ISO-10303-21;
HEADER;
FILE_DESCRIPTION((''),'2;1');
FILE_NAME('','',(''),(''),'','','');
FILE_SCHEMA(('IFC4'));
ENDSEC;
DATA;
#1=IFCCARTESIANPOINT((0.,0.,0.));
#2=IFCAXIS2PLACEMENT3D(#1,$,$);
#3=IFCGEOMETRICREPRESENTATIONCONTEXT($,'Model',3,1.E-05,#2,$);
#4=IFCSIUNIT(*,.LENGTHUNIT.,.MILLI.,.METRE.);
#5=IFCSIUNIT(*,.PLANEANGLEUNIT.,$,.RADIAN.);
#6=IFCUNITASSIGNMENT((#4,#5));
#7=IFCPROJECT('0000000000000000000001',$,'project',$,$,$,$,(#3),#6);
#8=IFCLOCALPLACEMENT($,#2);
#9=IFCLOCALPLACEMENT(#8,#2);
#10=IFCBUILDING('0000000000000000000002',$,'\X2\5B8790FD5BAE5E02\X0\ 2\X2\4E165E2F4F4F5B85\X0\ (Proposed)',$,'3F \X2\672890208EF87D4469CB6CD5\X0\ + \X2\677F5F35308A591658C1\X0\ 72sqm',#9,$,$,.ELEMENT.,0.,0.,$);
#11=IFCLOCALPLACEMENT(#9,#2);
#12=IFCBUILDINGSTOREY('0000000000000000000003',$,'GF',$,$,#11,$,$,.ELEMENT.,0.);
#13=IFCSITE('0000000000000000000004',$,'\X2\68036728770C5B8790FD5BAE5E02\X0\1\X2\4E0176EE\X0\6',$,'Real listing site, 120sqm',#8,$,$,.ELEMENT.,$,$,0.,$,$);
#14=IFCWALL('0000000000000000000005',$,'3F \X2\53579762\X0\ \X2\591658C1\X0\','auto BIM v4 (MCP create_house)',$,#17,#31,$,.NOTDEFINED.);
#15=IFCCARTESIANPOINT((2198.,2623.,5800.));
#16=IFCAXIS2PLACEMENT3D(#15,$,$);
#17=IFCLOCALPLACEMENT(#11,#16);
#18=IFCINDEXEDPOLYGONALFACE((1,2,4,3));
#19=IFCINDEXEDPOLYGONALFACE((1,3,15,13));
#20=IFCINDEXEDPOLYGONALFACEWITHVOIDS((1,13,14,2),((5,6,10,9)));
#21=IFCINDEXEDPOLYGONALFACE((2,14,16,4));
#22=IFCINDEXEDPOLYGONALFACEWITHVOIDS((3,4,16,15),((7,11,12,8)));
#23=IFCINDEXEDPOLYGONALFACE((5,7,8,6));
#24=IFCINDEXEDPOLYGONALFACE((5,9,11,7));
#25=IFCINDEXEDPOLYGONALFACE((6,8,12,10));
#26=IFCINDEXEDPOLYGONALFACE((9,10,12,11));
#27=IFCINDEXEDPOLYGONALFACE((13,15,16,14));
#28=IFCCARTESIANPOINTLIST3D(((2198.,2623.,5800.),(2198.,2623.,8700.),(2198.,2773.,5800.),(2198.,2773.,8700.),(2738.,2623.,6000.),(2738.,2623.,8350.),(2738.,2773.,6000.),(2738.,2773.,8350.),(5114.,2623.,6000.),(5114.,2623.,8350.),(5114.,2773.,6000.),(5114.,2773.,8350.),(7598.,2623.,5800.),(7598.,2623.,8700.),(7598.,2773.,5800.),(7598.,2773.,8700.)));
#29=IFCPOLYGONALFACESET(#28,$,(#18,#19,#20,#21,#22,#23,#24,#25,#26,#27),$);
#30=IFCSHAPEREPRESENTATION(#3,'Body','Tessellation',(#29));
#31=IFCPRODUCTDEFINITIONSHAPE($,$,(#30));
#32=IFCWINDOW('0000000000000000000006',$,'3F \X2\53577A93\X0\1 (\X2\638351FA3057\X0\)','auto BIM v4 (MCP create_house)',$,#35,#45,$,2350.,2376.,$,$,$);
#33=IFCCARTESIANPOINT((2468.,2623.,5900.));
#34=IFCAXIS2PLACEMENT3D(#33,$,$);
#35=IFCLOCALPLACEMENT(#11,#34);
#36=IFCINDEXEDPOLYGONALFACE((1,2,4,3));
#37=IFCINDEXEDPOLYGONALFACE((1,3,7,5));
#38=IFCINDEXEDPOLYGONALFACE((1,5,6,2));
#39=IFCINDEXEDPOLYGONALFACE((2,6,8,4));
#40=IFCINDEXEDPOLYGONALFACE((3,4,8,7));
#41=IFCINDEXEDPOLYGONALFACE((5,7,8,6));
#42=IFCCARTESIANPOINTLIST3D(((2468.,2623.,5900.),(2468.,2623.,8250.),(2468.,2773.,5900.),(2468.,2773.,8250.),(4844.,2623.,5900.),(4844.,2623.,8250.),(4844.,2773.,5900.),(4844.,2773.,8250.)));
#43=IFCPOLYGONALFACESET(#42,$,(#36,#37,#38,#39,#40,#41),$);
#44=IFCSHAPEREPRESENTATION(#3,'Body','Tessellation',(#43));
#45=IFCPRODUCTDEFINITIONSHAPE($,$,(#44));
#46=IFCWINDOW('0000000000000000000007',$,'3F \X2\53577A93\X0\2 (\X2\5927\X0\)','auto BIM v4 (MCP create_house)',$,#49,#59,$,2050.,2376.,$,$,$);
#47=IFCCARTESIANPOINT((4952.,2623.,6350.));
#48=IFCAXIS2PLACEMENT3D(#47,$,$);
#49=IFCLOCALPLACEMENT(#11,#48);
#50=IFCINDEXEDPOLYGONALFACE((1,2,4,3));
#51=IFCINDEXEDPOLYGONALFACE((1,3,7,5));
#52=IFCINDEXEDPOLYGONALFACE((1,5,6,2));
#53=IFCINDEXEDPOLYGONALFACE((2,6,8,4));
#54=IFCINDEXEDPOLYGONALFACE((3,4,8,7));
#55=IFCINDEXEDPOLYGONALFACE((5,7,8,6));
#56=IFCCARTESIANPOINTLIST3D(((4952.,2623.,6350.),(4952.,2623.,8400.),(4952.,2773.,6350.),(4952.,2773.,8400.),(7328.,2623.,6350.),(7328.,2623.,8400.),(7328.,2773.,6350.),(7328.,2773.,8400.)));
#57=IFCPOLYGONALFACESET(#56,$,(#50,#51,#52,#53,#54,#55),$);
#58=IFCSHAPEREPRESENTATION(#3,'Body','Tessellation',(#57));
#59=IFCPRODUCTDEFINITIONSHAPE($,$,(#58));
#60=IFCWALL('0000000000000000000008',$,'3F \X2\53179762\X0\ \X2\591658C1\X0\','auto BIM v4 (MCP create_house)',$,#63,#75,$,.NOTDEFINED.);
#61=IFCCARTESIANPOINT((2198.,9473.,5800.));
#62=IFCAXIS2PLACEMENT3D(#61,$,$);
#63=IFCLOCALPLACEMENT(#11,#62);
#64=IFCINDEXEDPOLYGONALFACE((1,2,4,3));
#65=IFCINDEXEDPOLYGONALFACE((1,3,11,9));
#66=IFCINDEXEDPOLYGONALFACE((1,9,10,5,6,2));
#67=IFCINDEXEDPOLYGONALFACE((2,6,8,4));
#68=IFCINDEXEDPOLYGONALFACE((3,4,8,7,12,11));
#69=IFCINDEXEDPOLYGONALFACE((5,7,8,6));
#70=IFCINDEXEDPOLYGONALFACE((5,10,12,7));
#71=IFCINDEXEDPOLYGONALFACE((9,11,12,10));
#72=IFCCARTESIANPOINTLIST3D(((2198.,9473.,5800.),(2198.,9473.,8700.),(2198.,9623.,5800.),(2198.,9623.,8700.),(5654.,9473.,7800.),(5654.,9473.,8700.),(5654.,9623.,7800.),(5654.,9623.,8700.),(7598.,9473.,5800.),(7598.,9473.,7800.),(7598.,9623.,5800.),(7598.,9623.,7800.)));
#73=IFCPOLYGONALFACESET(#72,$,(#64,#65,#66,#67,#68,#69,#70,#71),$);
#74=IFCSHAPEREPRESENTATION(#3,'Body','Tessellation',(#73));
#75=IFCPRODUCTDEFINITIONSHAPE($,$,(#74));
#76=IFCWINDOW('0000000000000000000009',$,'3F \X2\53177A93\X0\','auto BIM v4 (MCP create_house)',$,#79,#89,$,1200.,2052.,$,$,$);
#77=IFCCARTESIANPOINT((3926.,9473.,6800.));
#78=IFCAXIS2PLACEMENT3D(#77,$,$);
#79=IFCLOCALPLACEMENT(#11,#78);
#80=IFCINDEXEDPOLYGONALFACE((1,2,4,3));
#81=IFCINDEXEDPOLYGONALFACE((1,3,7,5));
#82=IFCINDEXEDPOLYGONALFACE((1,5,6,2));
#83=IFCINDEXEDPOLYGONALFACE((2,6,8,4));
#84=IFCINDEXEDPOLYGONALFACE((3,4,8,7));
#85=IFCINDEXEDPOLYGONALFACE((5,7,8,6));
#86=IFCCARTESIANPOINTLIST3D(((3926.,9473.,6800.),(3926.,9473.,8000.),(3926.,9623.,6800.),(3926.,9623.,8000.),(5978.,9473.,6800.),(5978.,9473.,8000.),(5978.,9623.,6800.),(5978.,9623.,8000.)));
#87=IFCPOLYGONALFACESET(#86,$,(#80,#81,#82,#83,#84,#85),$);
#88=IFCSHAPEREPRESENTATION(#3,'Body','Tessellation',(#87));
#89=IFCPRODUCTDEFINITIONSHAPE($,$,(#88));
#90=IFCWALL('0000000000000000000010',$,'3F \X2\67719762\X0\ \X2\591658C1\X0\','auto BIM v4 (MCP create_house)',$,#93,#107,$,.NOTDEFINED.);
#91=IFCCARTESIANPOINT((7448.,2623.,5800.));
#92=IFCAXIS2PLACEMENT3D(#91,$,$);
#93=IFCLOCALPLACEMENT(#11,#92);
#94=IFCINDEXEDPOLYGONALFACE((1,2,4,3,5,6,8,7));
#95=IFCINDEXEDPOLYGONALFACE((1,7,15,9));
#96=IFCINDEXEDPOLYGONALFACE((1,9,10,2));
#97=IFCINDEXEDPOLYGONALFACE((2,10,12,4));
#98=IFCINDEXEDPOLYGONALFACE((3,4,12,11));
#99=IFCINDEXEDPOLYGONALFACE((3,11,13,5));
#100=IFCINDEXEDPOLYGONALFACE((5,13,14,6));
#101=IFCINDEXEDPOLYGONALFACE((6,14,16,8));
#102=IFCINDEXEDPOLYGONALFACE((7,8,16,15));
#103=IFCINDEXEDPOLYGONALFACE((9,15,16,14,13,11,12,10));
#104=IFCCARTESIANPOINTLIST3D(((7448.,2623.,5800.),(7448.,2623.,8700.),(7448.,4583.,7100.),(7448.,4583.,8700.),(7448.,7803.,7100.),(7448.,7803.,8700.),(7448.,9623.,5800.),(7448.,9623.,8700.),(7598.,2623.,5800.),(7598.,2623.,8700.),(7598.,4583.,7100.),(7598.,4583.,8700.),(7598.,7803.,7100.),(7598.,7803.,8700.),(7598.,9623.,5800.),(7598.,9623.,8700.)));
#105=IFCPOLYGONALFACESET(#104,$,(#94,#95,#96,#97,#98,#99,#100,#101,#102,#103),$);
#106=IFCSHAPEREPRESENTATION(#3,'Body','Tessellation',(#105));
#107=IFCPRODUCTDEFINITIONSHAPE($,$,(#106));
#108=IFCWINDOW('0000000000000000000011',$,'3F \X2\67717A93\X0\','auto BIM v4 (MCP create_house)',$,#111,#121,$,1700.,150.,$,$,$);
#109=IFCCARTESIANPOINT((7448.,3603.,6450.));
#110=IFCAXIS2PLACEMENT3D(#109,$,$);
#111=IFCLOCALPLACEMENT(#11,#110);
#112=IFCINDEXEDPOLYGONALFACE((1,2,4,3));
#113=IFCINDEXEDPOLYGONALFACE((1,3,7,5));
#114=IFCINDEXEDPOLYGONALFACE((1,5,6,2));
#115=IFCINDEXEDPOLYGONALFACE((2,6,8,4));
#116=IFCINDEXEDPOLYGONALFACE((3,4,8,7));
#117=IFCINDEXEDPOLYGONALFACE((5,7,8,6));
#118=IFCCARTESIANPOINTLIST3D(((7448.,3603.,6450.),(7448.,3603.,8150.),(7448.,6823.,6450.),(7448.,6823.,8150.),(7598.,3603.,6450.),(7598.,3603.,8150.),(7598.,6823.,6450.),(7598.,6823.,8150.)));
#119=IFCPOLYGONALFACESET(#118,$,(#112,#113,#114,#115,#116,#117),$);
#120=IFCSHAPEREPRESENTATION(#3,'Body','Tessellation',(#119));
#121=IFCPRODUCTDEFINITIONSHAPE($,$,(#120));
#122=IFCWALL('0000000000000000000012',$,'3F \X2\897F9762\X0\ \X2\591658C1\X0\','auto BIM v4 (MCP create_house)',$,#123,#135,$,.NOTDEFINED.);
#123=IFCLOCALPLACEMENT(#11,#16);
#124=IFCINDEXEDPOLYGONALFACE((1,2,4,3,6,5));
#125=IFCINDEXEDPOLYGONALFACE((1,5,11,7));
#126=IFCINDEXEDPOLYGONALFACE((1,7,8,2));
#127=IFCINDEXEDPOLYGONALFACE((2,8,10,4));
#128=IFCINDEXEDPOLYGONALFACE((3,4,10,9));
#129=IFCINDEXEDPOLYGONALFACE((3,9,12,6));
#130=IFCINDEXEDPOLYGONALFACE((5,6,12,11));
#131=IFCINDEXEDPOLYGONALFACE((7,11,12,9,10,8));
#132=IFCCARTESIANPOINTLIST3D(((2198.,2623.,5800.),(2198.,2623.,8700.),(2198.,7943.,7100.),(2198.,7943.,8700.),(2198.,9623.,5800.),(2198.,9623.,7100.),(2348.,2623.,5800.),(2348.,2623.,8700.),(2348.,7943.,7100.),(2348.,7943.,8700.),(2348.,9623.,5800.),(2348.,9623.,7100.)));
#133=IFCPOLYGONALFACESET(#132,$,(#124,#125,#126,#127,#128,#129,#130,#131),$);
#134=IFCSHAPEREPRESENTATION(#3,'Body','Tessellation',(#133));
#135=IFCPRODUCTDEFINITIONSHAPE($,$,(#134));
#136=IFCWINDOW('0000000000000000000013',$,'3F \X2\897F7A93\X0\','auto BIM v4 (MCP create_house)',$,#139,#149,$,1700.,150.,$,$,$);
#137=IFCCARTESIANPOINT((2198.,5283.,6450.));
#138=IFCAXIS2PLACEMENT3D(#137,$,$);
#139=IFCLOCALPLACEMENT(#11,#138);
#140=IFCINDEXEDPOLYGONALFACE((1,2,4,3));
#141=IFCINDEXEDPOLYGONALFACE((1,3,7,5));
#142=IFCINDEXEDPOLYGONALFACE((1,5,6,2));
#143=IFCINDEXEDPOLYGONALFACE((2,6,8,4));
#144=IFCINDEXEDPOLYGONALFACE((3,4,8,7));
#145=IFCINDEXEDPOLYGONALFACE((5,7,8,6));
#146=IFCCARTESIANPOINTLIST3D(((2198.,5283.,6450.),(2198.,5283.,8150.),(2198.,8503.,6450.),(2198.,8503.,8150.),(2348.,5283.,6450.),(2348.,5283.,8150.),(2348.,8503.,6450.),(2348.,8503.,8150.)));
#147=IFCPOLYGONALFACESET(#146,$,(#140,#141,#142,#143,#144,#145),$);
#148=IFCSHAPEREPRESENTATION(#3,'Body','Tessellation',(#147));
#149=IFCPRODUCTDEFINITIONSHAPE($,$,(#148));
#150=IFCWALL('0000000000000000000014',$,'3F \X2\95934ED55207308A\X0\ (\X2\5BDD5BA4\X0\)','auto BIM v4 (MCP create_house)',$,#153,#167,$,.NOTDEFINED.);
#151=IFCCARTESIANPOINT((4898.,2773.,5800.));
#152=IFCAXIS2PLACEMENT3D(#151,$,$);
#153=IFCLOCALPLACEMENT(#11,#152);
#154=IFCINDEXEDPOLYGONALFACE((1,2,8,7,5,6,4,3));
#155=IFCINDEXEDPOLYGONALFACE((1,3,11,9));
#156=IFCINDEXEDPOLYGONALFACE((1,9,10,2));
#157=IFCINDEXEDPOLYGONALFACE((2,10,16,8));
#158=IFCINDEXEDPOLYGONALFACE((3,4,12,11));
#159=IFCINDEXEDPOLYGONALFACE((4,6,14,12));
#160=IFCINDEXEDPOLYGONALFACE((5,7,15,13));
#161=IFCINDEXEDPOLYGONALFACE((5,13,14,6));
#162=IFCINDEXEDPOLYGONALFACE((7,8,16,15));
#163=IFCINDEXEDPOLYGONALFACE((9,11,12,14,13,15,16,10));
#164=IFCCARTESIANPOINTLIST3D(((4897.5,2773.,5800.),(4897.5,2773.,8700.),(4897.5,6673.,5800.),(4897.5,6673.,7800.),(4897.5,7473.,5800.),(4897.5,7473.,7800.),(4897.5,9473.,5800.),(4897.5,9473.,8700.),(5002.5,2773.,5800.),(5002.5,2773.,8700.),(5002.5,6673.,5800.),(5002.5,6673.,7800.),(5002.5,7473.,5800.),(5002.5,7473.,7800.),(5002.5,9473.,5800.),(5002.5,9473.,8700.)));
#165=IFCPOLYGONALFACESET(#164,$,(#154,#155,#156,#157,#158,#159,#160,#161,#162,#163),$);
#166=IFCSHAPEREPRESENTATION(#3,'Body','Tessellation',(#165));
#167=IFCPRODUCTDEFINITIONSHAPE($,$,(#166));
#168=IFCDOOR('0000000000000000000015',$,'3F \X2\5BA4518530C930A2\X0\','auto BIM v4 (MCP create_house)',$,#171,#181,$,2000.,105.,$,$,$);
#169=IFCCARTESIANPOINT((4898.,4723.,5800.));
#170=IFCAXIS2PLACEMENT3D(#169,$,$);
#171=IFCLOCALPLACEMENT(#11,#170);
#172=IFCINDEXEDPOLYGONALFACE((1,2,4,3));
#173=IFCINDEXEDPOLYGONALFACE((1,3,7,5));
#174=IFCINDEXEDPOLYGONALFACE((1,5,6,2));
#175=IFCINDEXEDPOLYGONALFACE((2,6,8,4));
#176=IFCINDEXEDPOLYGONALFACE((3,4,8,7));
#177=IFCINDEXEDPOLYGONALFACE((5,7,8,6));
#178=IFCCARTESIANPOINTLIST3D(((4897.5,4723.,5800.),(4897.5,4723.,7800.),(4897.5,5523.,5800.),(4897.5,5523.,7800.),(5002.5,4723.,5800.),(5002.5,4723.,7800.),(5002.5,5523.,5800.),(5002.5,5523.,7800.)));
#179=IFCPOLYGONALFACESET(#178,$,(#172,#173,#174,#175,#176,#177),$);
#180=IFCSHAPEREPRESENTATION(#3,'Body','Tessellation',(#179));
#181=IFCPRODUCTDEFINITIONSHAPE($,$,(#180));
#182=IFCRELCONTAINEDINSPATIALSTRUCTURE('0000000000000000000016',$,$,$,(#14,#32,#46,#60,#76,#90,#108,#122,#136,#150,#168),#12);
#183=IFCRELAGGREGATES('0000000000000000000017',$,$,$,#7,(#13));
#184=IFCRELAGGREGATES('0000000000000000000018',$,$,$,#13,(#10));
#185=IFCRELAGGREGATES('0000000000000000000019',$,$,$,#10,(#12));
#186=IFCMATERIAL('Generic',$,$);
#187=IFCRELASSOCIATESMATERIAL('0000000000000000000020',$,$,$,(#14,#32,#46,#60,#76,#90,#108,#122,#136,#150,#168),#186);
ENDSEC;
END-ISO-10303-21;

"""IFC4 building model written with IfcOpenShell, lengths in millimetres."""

from ifc_helpers import new_model, si_unit, frame, frame_2d, origin, place, context, project, spatial, rectangle, extrude, material, element, fill, save


model = new_model("IFC4")

# Units and contexts
model_context = context("Model", 3, precision=1e-05, world=origin())
ifc_project = project(units=[si_unit("LENGTHUNIT", "METRE", prefix="MILLI"), si_unit("PLANEANGLEUNIT", "RADIAN")], contexts=[model_context])

# Site, building, storey
site_placement = place(None, origin())
site = spatial("IfcSite", under=ifc_project, at=site_placement, Name="栃木県宇都宮市1丁目6", ObjectType="Real listing site, 120sqm", CompositionType="ELEMENT", RefElevation=0.0)
building_placement = place(site_placement, origin())
building = spatial("IfcBuilding", under=site, at=building_placement, Name="宇都宮市 2世帯住宅 (Proposed)", ObjectType="3F 木造軸組構法 + 板張り外壁 72sqm", CompositionType="ELEMENT", ElevationOfRefHeight=0.0, ElevationOfTerrain=0.0)
storey_placement = place(building_placement, origin())
storey = spatial("IfcBuildingStorey", under=building, at=storey_placement, Name="GF", CompositionType="ELEMENT", Elevation=0.0)

# Shared definitions
ifc_material = material(Name="Generic")

# Wall, openings, windows
wall_1_placement = place(storey_placement, frame((2198.0, 2623.0, 5800.0)))
wall_1 = element("IfcWall", 1, at=wall_1_placement, inside=storey, material=ifc_material, Name="3F 南面 外壁", Description="auto BIM v4 (MCP create_house)", PredefinedType="NOTDEFINED", context=model_context, shape_type="SweptSolid", body=[
    extrude(rectangle(XDim=5400.0, YDim=150.0, at=frame_2d((2700.0, 75.0))), frame((2198.0, 2623.0, 5800.0)), (0.0, 0.0, 1.0), 2900.0),
])
opening_1_placement = place(storey_placement, frame((2468.0, 2623.0, 5900.0)))
opening_1 = element("IfcOpeningElement", 2, at=opening_1_placement, cuts=wall_1, PredefinedType="NOTDEFINED", context=model_context, shape_type="SweptSolid", body=[
    extrude(rectangle(XDim=2376.0, YDim=150.0, at=frame_2d((1188.0, 75.0))), frame((2468.0, 2623.0, 5900.0)), (0.0, 0.0, 1.0), 2350.0),
])
opening_2_placement = place(storey_placement, frame((4952.0, 2623.0, 6350.0)))
opening_2 = element("IfcOpeningElement", 3, at=opening_2_placement, cuts=wall_1, PredefinedType="NOTDEFINED", context=model_context, shape_type="SweptSolid", body=[
    extrude(rectangle(XDim=2376.0, YDim=150.0, at=frame_2d((1188.0, 75.0))), frame((4952.0, 2623.0, 6350.0)), (0.0, 0.0, 1.0), 2050.0),
])
window_1_placement = place(storey_placement, frame((2468.0, 2623.0, 5900.0)))
window_1 = element("IfcWindow", 4, at=window_1_placement, inside=storey, material=ifc_material, Name="3F 南窓1 (掃出し)", Description="auto BIM v4 (MCP create_house)", OverallHeight=2350.0, OverallWidth=2376.0, context=model_context, shape_type="SweptSolid", body=[
    extrude(rectangle(XDim=2376.0, YDim=150.0, at=frame_2d((1188.0, 75.0))), frame((2468.0, 2623.0, 5900.0)), (0.0, 0.0, 1.0), 2350.0),
])
fill(opening_1, window_1)
window_2_placement = place(storey_placement, frame((4952.0, 2623.0, 6350.0)))
window_2 = element("IfcWindow", 5, at=window_2_placement, inside=storey, material=ifc_material, Name="3F 南窓2 (大)", Description="auto BIM v4 (MCP create_house)", OverallHeight=2050.0, OverallWidth=2376.0, context=model_context, shape_type="SweptSolid", body=[
    extrude(rectangle(XDim=2376.0, YDim=150.0, at=frame_2d((1188.0, 75.0))), frame((4952.0, 2623.0, 6350.0)), (0.0, 0.0, 1.0), 2050.0),
])
fill(opening_2, window_2)

# Walls, openings, windows
wall_2_placement = place(storey_placement, frame((2198.0, 9473.0, 5800.0)))
wall_2 = element("IfcWall", 6, at=wall_2_placement, inside=storey, material=ifc_material, Name="3F 北面 外壁", Description="auto BIM v4 (MCP create_house)", PredefinedType="NOTDEFINED", context=model_context, shape_type="SweptSolid", body=[
    extrude(rectangle(XDim=5400.0, YDim=150.0, at=frame_2d((2700.0, 75.0))), frame((2198.0, 9473.0, 5800.0)), (0.0, 0.0, 1.0), 2900.0),
])
opening_3_placement = place(storey_placement, frame((3926.0, 9473.0, 6800.0)))
opening_3 = element("IfcOpeningElement", 7, at=opening_3_placement, cuts=wall_2, PredefinedType="NOTDEFINED", context=model_context, shape_type="SweptSolid", body=[
    extrude(rectangle(XDim=2052.0, YDim=150.0, at=frame_2d((1026.0, 75.0))), frame((3926.0, 9473.0, 6800.0)), (0.0, 0.0, 1.0), 1200.0),
])
window_3_placement = place(storey_placement, frame((3926.0, 9473.0, 6800.0)))
window_3 = element("IfcWindow", 8, at=window_3_placement, inside=storey, material=ifc_material, Name="3F 北窓", Description="auto BIM v4 (MCP create_house)", OverallHeight=1200.0, OverallWidth=2052.0, context=model_context, shape_type="SweptSolid", body=[
    extrude(rectangle(XDim=2052.0, YDim=150.0, at=frame_2d((1026.0, 75.0))), frame((3926.0, 9473.0, 6800.0)), (0.0, 0.0, 1.0), 1200.0),
])
fill(opening_3, window_3)
wall_3_placement = place(storey_placement, frame((7448.0, 2623.0, 5800.0)))
wall_3 = element("IfcWall", 9, at=wall_3_placement, inside=storey, material=ifc_material, Name="3F 東面 外壁", Description="auto BIM v4 (MCP create_house)", PredefinedType="NOTDEFINED", context=model_context, shape_type="SweptSolid", body=[
    extrude(rectangle(XDim=150.0, YDim=7000.0, at=frame_2d((75.0, 3500.0))), frame((7448.0, 2623.0, 5800.0)), (0.0, 0.0, 1.0), 2900.0),
])
opening_4_placement = place(storey_placement, frame((7448.0, 3603.0, 6450.0)))
opening_4 = element("IfcOpeningElement", 10, at=opening_4_placement, cuts=wall_3, PredefinedType="NOTDEFINED", context=model_context, shape_type="SweptSolid", body=[
    extrude(rectangle(XDim=150.0, YDim=3220.0, at=frame_2d((75.0, 1610.0))), frame((7448.0, 3603.0, 6450.0)), (0.0, 0.0, 1.0), 1700.0),
])
window_4_placement = place(storey_placement, frame((7448.0, 3603.0, 6450.0)))
window_4 = element("IfcWindow", 11, at=window_4_placement, inside=storey, material=ifc_material, Name="3F 東窓", Description="auto BIM v4 (MCP create_house)", OverallHeight=1700.0, OverallWidth=150.0, context=model_context, shape_type="SweptSolid", body=[
    extrude(rectangle(XDim=150.0, YDim=3220.0, at=frame_2d((75.0, 1610.0))), frame((7448.0, 3603.0, 6450.0)), (0.0, 0.0, 1.0), 1700.0),
])
fill(opening_4, window_4)
wall_4_placement = place(storey_placement, frame((2198.0, 2623.0, 5800.0)))
wall_4 = element("IfcWall", 12, at=wall_4_placement, inside=storey, material=ifc_material, Name="3F 西面 外壁", Description="auto BIM v4 (MCP create_house)", PredefinedType="NOTDEFINED", context=model_context, shape_type="SweptSolid", body=[
    extrude(rectangle(XDim=150.0, YDim=7000.0, at=frame_2d((75.0, 3500.0))), frame((2198.0, 2623.0, 5800.0)), (0.0, 0.0, 1.0), 2900.0),
])
opening_5_placement = place(storey_placement, frame((2198.0, 5283.0, 6450.0)))
opening_5 = element("IfcOpeningElement", 13, at=opening_5_placement, cuts=wall_4, PredefinedType="NOTDEFINED", context=model_context, shape_type="SweptSolid", body=[
    extrude(rectangle(XDim=150.0, YDim=3220.0, at=frame_2d((75.0, 1610.0))), frame((2198.0, 5283.0, 6450.0)), (0.0, 0.0, 1.0), 1700.0),
])
window_5_placement = place(storey_placement, frame((2198.0, 5283.0, 6450.0)))
window_5 = element("IfcWindow", 14, at=window_5_placement, inside=storey, material=ifc_material, Name="3F 西窓", Description="auto BIM v4 (MCP create_house)", OverallHeight=1700.0, OverallWidth=150.0, context=model_context, shape_type="SweptSolid", body=[
    extrude(rectangle(XDim=150.0, YDim=3220.0, at=frame_2d((75.0, 1610.0))), frame((2198.0, 5283.0, 6450.0)), (0.0, 0.0, 1.0), 1700.0),
])
fill(opening_5, window_5)

# Wall, opening, door
wall_5_placement = place(storey_placement, frame((4898.0, 2773.0, 5800.0)))
wall_5 = element("IfcWall", 15, at=wall_5_placement, inside=storey, material=ifc_material, Name="3F 間仕切り (寝室)", Description="auto BIM v4 (MCP create_house)", PredefinedType="NOTDEFINED", context=model_context, shape_type="SweptSolid", body=[
    extrude(rectangle(XDim=105.0, YDim=6700.0, at=frame_2d((52.0, 3350.0))), frame((4898.0, 2773.0, 5800.0)), (0.0, 0.0, 1.0), 2900.0),
])
opening_6_placement = place(storey_placement, frame((4898.0, 4723.0, 5800.0)))
opening_6 = element("IfcOpeningElement", 16, at=opening_6_placement, cuts=wall_5, PredefinedType="NOTDEFINED", context=model_context, shape_type="SweptSolid", body=[
    extrude(rectangle(XDim=105.0, YDim=800.0, at=frame_2d((52.0, 400.0))), frame((4898.0, 4723.0, 5800.0)), (0.0, 0.0, 1.0), 2000.0),
])
door_1_placement = place(storey_placement, frame((4898.0, 4723.0, 5800.0)))
door_1 = element("IfcDoor", 17, at=door_1_placement, inside=storey, material=ifc_material, Name="3F 室内ドア", Description="auto BIM v4 (MCP create_house)", OverallHeight=2000.0, OverallWidth=105.0, context=model_context, shape_type="SweptSolid", body=[
    extrude(rectangle(XDim=105.0, YDim=800.0, at=frame_2d((52.0, 400.0))), frame((4898.0, 4723.0, 5800.0)), (0.0, 0.0, 1.0), 2000.0),
])
fill(opening_6, door_1)

save(model, "model.ifc")
